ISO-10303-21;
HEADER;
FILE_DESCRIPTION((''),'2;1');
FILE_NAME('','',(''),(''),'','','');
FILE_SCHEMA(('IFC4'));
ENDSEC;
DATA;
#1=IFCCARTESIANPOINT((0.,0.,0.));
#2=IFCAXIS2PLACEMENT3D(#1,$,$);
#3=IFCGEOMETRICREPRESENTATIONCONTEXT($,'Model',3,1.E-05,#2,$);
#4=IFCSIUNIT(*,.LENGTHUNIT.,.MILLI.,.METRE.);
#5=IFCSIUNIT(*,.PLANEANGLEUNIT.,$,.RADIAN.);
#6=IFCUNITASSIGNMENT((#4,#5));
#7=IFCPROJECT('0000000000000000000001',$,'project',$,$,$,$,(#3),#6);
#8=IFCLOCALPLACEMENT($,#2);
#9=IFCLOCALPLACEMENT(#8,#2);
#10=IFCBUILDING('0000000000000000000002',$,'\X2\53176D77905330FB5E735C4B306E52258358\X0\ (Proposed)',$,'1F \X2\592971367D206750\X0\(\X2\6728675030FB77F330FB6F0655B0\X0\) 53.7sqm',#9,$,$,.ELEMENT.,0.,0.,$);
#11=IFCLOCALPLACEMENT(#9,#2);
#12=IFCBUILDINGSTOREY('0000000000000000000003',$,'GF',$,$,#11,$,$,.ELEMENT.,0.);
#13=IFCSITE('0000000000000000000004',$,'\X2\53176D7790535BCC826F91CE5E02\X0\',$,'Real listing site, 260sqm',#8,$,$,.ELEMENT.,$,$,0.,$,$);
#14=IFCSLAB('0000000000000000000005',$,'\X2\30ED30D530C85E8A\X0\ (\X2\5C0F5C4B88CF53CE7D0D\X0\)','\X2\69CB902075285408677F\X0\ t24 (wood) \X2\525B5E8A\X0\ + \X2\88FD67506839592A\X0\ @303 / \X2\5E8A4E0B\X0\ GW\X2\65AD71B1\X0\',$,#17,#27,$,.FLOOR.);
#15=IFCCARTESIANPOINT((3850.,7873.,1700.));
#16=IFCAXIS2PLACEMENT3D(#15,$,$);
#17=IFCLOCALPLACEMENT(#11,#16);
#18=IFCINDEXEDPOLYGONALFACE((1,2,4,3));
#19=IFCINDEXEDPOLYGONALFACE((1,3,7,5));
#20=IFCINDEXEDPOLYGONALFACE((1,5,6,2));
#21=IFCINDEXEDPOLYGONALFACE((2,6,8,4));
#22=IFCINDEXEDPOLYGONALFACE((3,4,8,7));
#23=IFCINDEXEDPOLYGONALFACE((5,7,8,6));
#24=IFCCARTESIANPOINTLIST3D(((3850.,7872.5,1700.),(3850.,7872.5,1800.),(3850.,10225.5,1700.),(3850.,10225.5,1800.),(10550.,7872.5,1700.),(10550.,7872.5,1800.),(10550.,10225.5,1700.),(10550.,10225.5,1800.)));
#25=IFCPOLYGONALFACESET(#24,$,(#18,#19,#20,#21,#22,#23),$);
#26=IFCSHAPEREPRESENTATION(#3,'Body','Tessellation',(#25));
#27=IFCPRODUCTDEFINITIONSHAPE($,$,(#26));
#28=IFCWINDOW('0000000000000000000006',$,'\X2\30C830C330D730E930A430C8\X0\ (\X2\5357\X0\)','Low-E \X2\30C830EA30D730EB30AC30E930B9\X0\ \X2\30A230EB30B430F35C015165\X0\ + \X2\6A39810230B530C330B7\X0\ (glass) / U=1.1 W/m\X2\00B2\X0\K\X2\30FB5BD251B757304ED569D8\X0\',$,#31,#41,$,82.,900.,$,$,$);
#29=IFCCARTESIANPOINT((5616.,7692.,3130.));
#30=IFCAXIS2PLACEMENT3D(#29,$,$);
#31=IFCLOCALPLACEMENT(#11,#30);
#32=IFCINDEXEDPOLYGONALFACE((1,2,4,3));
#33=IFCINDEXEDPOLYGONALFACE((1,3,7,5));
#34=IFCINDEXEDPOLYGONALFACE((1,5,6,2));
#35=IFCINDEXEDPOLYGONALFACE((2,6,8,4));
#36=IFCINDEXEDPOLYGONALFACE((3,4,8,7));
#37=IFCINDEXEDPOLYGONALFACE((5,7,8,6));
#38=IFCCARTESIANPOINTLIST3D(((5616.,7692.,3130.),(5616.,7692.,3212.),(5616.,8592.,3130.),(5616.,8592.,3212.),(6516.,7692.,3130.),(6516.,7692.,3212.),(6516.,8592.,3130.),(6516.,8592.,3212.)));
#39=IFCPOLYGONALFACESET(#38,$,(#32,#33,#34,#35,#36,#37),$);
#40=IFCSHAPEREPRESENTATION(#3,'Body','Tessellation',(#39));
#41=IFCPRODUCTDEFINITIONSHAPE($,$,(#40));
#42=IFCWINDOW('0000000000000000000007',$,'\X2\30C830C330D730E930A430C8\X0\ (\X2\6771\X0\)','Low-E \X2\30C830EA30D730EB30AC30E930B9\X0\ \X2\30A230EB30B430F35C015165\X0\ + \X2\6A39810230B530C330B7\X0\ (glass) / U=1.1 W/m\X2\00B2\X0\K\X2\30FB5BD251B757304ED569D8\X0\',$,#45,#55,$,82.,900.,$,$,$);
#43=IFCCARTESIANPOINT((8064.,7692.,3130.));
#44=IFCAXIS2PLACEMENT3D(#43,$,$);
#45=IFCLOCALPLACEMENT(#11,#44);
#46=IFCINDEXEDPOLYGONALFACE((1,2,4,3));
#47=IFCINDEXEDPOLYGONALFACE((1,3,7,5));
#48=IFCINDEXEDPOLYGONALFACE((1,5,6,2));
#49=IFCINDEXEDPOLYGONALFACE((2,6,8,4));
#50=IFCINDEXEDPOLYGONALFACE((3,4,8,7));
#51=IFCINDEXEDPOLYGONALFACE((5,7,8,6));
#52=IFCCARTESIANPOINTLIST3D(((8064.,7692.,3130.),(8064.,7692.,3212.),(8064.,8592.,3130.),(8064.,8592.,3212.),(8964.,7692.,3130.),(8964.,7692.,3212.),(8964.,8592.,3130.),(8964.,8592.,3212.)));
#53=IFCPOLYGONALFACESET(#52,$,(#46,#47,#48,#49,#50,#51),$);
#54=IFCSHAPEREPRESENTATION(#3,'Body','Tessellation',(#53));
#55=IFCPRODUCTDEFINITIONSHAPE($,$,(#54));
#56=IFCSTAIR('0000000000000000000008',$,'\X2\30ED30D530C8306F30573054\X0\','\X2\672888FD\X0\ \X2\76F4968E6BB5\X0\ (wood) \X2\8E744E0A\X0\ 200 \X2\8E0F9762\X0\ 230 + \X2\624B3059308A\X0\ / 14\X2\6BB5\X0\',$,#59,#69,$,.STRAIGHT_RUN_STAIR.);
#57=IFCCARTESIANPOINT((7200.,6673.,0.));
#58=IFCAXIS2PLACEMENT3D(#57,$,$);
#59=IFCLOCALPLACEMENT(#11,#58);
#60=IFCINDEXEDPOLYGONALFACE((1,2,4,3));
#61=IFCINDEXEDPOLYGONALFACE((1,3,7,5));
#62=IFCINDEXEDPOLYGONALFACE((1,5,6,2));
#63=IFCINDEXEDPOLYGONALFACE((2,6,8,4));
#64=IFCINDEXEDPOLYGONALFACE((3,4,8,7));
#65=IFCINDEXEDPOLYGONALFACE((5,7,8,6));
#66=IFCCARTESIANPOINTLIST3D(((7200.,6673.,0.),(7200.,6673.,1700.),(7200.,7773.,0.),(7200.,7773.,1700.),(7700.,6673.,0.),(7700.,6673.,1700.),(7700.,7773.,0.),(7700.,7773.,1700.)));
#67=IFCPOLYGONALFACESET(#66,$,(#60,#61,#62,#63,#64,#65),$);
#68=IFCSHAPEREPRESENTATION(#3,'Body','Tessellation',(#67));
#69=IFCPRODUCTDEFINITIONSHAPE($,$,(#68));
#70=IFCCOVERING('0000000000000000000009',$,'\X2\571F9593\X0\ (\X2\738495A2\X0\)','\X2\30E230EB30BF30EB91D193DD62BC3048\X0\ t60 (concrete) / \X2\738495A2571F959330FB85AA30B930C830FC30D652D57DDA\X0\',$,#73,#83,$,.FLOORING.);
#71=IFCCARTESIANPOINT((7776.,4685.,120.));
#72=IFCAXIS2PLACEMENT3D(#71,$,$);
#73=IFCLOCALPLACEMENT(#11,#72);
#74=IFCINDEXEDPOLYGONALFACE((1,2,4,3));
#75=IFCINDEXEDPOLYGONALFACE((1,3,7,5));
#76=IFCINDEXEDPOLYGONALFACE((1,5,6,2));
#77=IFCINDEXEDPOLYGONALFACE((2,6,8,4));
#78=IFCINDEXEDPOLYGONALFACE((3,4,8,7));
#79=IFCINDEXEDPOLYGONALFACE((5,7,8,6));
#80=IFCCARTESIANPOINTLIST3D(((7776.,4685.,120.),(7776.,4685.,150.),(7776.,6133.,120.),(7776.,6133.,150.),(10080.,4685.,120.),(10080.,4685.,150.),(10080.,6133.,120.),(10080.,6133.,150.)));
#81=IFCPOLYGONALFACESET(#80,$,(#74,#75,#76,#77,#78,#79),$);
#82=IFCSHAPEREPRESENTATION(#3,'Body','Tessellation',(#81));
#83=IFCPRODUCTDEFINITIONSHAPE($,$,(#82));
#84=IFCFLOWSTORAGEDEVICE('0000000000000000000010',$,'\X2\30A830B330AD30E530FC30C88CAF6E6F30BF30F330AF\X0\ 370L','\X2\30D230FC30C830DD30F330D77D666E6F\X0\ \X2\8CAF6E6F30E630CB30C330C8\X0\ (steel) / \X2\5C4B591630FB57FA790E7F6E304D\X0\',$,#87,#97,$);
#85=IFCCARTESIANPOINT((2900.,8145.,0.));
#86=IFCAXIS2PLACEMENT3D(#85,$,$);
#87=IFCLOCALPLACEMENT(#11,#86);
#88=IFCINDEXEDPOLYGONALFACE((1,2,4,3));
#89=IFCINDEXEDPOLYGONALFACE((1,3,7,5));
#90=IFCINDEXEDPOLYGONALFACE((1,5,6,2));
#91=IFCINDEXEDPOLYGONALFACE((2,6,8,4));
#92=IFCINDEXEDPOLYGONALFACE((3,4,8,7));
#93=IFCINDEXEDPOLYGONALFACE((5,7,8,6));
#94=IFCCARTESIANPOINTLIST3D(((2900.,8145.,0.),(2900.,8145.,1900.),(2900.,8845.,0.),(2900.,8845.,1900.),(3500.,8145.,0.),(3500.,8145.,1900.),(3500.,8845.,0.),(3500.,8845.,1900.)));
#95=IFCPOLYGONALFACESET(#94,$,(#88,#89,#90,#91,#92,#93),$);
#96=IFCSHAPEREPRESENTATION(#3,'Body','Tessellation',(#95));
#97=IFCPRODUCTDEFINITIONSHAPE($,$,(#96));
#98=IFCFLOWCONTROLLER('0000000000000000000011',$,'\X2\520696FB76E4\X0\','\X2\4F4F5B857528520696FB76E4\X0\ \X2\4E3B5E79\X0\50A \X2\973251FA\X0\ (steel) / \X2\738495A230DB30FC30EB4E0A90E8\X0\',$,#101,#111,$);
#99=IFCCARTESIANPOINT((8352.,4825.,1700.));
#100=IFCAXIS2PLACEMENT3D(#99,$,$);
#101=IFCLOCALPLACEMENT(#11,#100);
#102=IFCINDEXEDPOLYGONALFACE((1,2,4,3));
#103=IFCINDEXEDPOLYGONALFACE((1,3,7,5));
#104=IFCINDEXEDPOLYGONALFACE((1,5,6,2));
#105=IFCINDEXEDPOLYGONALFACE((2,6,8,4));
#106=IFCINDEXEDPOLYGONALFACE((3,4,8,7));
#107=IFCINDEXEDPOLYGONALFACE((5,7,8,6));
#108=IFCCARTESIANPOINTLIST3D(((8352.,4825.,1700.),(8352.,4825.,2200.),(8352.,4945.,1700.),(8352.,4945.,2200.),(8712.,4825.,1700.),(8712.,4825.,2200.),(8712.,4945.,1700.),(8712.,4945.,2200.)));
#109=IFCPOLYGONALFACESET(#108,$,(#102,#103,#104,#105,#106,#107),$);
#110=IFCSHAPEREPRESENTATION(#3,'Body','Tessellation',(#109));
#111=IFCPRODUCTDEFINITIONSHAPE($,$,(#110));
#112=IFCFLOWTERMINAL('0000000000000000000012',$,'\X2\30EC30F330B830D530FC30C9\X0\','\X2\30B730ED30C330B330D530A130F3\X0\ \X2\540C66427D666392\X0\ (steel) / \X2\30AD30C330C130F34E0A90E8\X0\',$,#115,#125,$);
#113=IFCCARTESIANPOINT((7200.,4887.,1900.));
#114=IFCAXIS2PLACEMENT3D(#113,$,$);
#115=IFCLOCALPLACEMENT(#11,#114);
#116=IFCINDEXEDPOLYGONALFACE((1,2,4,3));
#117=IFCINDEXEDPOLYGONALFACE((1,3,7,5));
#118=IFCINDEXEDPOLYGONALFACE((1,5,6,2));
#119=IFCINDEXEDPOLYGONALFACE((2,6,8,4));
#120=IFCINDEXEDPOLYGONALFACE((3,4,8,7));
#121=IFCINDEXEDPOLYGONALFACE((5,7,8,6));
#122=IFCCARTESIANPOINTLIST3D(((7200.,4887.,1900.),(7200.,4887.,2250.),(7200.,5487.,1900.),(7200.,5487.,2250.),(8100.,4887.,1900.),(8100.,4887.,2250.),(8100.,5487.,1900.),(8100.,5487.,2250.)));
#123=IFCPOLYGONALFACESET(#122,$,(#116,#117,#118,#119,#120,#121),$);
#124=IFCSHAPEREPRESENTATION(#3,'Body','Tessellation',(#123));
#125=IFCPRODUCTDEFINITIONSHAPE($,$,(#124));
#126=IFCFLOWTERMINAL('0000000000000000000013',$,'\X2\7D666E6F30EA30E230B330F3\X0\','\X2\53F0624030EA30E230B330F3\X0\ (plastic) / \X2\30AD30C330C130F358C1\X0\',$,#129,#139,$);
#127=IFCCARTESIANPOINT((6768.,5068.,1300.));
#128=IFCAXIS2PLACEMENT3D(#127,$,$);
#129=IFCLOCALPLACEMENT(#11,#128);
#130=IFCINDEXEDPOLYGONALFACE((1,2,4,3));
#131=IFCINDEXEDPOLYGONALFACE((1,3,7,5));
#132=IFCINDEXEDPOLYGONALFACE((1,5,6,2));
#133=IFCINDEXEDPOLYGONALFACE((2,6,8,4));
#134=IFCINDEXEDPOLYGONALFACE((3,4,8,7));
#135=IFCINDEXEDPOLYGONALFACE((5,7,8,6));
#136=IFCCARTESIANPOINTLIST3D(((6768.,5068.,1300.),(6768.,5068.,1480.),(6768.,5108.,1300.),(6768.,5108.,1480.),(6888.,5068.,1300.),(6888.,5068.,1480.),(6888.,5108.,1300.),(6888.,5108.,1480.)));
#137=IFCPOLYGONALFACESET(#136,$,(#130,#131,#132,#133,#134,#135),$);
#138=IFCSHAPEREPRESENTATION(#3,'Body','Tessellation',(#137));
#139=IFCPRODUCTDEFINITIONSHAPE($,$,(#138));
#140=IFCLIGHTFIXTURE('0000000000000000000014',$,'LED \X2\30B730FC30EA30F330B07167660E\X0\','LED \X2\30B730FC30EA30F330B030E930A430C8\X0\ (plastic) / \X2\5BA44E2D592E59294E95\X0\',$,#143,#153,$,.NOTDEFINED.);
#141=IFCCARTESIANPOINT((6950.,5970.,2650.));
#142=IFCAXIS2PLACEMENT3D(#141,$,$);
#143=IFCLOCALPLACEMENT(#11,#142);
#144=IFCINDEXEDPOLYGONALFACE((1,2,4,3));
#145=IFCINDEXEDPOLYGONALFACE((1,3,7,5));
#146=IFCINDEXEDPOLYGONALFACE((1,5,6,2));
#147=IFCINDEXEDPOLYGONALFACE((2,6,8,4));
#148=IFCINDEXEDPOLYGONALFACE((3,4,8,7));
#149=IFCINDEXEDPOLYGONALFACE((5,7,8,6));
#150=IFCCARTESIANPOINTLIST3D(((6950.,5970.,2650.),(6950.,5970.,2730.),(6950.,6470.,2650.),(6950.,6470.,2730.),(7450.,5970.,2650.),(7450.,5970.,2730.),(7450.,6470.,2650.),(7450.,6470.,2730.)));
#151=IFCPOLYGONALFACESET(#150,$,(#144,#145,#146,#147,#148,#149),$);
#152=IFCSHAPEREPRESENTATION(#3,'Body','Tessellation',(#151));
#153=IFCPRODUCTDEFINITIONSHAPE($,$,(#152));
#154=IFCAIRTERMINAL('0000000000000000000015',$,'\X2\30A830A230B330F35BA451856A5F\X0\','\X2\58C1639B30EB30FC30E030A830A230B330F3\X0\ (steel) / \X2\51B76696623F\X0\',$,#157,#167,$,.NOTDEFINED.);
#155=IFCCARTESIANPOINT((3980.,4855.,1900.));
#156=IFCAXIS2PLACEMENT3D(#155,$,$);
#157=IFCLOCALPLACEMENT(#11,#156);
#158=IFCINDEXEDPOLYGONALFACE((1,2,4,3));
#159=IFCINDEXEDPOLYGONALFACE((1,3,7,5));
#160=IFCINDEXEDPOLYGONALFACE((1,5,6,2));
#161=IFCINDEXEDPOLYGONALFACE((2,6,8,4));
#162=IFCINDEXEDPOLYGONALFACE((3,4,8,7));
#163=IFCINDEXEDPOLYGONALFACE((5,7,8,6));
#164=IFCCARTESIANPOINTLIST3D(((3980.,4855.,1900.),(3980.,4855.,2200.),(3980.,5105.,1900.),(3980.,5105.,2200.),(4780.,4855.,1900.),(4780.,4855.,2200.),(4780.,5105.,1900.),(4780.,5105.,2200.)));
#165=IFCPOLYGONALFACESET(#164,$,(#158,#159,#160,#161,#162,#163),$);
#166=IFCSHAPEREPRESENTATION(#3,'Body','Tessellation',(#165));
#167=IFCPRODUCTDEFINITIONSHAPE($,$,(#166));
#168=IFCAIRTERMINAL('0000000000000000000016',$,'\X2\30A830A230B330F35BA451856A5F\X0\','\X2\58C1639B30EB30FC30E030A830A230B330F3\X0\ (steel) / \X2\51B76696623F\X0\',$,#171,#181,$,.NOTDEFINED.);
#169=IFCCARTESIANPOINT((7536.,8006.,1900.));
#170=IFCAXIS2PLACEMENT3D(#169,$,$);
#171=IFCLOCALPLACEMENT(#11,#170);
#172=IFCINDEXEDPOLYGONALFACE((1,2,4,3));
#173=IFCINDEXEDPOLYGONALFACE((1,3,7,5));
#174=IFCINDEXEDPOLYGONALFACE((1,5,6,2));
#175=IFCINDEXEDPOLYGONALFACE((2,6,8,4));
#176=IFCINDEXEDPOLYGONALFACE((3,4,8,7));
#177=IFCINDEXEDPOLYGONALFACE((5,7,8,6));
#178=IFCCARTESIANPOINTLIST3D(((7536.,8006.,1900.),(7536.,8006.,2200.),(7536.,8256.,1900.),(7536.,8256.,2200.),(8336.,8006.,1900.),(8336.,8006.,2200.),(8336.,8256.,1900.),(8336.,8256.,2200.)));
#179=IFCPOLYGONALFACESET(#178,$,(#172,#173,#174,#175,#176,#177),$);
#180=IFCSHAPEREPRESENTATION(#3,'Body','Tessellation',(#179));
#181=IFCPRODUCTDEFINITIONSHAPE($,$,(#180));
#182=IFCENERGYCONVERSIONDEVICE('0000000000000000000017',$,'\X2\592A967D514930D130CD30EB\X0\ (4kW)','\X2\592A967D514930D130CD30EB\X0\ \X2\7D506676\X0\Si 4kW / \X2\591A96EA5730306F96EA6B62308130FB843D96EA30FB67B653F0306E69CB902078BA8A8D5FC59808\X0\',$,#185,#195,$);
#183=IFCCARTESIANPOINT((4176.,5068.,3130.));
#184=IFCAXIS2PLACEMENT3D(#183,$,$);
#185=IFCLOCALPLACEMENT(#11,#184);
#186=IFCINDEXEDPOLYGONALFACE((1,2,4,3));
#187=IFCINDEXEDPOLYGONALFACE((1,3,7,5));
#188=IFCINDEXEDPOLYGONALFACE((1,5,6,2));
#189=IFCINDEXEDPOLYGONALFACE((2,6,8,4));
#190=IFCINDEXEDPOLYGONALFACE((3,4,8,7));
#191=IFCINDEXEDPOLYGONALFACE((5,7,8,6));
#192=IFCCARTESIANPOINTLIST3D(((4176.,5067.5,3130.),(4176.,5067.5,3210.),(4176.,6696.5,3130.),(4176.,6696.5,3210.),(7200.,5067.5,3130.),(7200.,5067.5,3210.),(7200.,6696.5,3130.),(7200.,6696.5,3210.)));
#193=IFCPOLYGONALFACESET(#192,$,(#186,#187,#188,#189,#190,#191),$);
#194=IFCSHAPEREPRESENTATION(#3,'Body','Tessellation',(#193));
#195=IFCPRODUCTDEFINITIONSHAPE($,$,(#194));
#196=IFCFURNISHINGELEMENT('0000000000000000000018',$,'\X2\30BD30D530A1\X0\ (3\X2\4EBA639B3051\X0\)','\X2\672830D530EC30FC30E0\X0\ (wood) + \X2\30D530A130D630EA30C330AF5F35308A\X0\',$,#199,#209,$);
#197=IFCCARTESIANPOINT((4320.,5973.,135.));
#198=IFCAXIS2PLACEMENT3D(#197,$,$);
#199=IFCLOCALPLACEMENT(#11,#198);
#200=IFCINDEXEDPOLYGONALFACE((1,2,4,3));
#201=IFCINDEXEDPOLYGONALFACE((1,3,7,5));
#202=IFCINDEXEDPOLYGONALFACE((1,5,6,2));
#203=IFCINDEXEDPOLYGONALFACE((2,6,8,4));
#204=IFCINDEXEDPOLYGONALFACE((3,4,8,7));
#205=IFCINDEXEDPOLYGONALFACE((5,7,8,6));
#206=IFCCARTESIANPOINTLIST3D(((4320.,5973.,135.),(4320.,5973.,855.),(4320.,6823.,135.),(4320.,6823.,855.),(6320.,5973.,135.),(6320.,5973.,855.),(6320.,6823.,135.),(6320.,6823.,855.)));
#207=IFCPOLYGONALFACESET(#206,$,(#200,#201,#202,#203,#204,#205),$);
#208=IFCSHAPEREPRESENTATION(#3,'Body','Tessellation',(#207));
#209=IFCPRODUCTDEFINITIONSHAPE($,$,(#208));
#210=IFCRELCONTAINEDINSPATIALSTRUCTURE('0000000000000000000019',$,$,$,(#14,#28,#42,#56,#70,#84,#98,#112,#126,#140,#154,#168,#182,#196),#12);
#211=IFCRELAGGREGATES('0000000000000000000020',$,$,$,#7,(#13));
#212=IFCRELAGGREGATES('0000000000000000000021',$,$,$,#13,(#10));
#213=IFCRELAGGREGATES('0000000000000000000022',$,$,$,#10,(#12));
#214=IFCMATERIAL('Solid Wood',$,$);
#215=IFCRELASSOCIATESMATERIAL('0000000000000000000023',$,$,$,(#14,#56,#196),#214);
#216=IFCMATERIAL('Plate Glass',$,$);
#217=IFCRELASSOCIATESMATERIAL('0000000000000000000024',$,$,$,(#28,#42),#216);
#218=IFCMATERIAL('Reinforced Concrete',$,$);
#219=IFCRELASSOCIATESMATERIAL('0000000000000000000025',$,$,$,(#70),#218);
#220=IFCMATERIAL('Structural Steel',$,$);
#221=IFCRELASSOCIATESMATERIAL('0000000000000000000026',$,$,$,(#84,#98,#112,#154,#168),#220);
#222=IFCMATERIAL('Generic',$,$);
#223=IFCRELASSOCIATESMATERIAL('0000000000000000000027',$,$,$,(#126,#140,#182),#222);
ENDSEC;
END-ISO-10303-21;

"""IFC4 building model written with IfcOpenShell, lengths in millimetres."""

from ifc_helpers import new_model, si_unit, frame, frame_2d, origin, place, context, project, spatial, rectangle, extrude, material, element, save


model = new_model("IFC4")

# Units and contexts
model_context = context("Model", 3, precision=1e-05, world=origin())
ifc_project = project(units=[si_unit("LENGTHUNIT", "METRE", prefix="MILLI"), si_unit("PLANEANGLEUNIT", "RADIAN")], contexts=[model_context])

# Site, building, storey
site_placement = place(None, origin())
site = spatial("IfcSite", under=ifc_project, at=site_placement, Name="北海道富良野市", ObjectType="Real listing site, 260sqm", CompositionType="ELEMENT", RefElevation=0.0)
building_placement = place(site_placement, origin())
building = spatial("IfcBuilding", under=site, at=building_placement, Name="北海道・平屋の別荘 (Proposed)", ObjectType="1F 天然素材(木材・石・漆喰) 53.7sqm", CompositionType="ELEMENT", ElevationOfRefHeight=0.0, ElevationOfTerrain=0.0)
storey_placement = place(building_placement, origin())
storey = spatial("IfcBuildingStorey", under=building, at=storey_placement, Name="GF", CompositionType="ELEMENT", Elevation=0.0)

# Shared definitions
ifc_material_1 = material(Name="Solid Wood")

# Slab
slab_placement = place(storey_placement, frame((3850.0, 7873.0, 1700.0)))
element("IfcSlab", 1, at=slab_placement, inside=storey, material=ifc_material_1, Name="ロフト床 (小屋裏収納)", Description="構造用合板 t24 (wood) 剛床 + 製材根太 @303 / 床下 GW断熱", PredefinedType="FLOOR", context=model_context, shape_type="SweptSolid", body=[
    extrude(rectangle(XDim=6700.0, YDim=2353.0, at=frame_2d((3350.0, 1176.0))), frame((3850.0, 7873.0, 1700.0)), (0.0, 0.0, 1.0), 100.0),
])

# Windows
ifc_material_2 = material(Name="Plate Glass")
window_1_placement = place(storey_placement, frame((5616.0, 7692.0, 3130.0)))
element("IfcWindow", 2, at=window_1_placement, inside=storey, material=ifc_material_2, Name="トップライト (南)", Description="Low-E トリプルガラス アルゴン封入 + 樹脂サッシ (glass) / U=1.1 W/m²K・寒冷地仕様", OverallHeight=82.0, OverallWidth=900.0, context=model_context, shape_type="SweptSolid", body=[
    extrude(rectangle(XDim=900.0, YDim=900.0, at=frame_2d((450.0, 450.0))), frame((5616.0, 7692.0, 3130.0)), (0.0, 0.0, 1.0), 82.0),
])
window_2_placement = place(storey_placement, frame((8064.0, 7692.0, 3130.0)))
element("IfcWindow", 3, at=window_2_placement, inside=storey, material=ifc_material_2, Name="トップライト (東)", Description="Low-E トリプルガラス アルゴン封入 + 樹脂サッシ (glass) / U=1.1 W/m²K・寒冷地仕様", OverallHeight=82.0, OverallWidth=900.0, context=model_context, shape_type="SweptSolid", body=[
    extrude(rectangle(XDim=900.0, YDim=900.0, at=frame_2d((450.0, 450.0))), frame((8064.0, 7692.0, 3130.0)), (0.0, 0.0, 1.0), 82.0),
])

# Stair
stair_placement = place(storey_placement, frame((7200.0, 6673.0, 0.0)))
element("IfcStair", 4, at=stair_placement, inside=storey, material=ifc_material_1, Name="ロフトはしご", Description="木製 直階段 (wood) 蹴上 200 踏面 230 + 手すり / 14段", PredefinedType="STRAIGHT_RUN_STAIR", context=model_context, shape_type="SweptSolid", body=[
    extrude(rectangle(XDim=500.0, YDim=1100.0, at=frame_2d((250.0, 550.0))), frame((7200.0, 6673.0, 0.0)), (0.0, 0.0, 1.0), 1700.0),
])

# Covering
ifc_material_3 = material(Name="Reinforced Concrete")
covering_placement = place(storey_placement, frame((7776.0, 4685.0, 120.0)))
element("IfcCovering", 5, at=covering_placement, inside=storey, material=ifc_material_3, Name="土間 (玄関)", Description="モルタル金鏝押え t60 (concrete) / 玄関土間・薪ストーブ動線", PredefinedType="FLOORING", context=model_context, shape_type="SweptSolid", body=[
    extrude(rectangle(XDim=2304.0, YDim=1448.0, at=frame_2d((1152.0, 724.0))), frame((7776.0, 4685.0, 120.0)), (0.0, 0.0, 1.0), 30.0),
])

# Flow storage device
ifc_material_4 = material(Name="Structural Steel")
flow_storage_device_placement = place(storey_placement, frame((2900.0, 8145.0, 0.0)))
element("IfcFlowStorageDevice", 6, at=flow_storage_device_placement, inside=storey, material=ifc_material_4, Name="エコキュート貯湯タンク 370L", Description="ヒートポンプ給湯 貯湯ユニット (steel) / 屋外・基礎置き", context=model_context, shape_type="SweptSolid", body=[
    extrude(rectangle(XDim=600.0, YDim=700.0, at=frame_2d((300.0, 350.0))), frame((2900.0, 8145.0, 0.0)), (0.0, 0.0, 1.0), 1900.0),
])

# Flow controller
flow_controller_placement = place(storey_placement, frame((8352.0, 4825.0, 1700.0)))
element("IfcFlowController", 7, at=flow_controller_placement, inside=storey, material=ifc_material_4, Name="分電盤", Description="住宅用分電盤 主幹50A 露出 (steel) / 玄関ホール上部", context=model_context, shape_type="SweptSolid", body=[
    extrude(rectangle(XDim=360.0, YDim=120.0, at=frame_2d((180.0, 60.0))), frame((8352.0, 4825.0, 1700.0)), (0.0, 0.0, 1.0), 500.0),
])

# Flow terminals
flow_terminal_1_placement = place(storey_placement, frame((7200.0, 4887.0, 1900.0)))
element("IfcFlowTerminal", 8, at=flow_terminal_1_placement, inside=storey, material=ifc_material_4, Name="レンジフード", Description="シロッコファン 同時給排 (steel) / キッチン上部", context=model_context, shape_type="SweptSolid", body=[
    extrude(rectangle(XDim=900.0, YDim=600.0, at=frame_2d((450.0, 300.0))), frame((7200.0, 4887.0, 1900.0)), (0.0, 0.0, 1.0), 350.0),
])
ifc_material_5 = material(Name="Generic")
flow_terminal_2_placement = place(storey_placement, frame((6768.0, 5068.0, 1300.0)))
element("IfcFlowTerminal", 9, at=flow_terminal_2_placement, inside=storey, material=ifc_material_5, Name="給湯リモコン", Description="台所リモコン (plastic) / キッチン壁", context=model_context, shape_type="SweptSolid", body=[
    extrude(rectangle(XDim=120.0, YDim=40.0, at=frame_2d((60.0, 20.0))), frame((6768.0, 5068.0, 1300.0)), (0.0, 0.0, 1.0), 180.0),
])

# Light fixture
light_fixture_placement = place(storey_placement, frame((6950.0, 5970.0, 2650.0)))
element("IfcLightFixture", 10, at=light_fixture_placement, inside=storey, material=ifc_material_5, Name="LED シーリング照明", Description="LED シーリングライト (plastic) / 室中央天井", PredefinedType="NOTDEFINED", context=model_context, shape_type="SweptSolid", body=[
    extrude(rectangle(XDim=500.0, YDim=500.0, at=frame_2d((250.0, 250.0))), frame((6950.0, 5970.0, 2650.0)), (0.0, 0.0, 1.0), 80.0),
])

# Air terminals
air_terminal_1_placement = place(storey_placement, frame((3980.0, 4855.0, 1900.0)))
element("IfcAirTerminal", 11, at=air_terminal_1_placement, inside=storey, material=ifc_material_4, Name="エアコン室内機", Description="壁掛ルームエアコン (steel) / 冷暖房", PredefinedType="NOTDEFINED", context=model_context, shape_type="SweptSolid", body=[
    extrude(rectangle(XDim=800.0, YDim=250.0, at=frame_2d((400.0, 125.0))), frame((3980.0, 4855.0, 1900.0)), (0.0, 0.0, 1.0), 300.0),
])
air_terminal_2_placement = place(storey_placement, frame((7536.0, 8006.0, 1900.0)))
element("IfcAirTerminal", 12, at=air_terminal_2_placement, inside=storey, material=ifc_material_4, Name="エアコン室内機", Description="壁掛ルームエアコン (steel) / 冷暖房", PredefinedType="NOTDEFINED", context=model_context, shape_type="SweptSolid", body=[
    extrude(rectangle(XDim=800.0, YDim=250.0, at=frame_2d((400.0, 125.0))), frame((7536.0, 8006.0, 1900.0)), (0.0, 0.0, 1.0), 300.0),
])

# Energy conversion device
energy_conversion_device_placement = place(storey_placement, frame((4176.0, 5068.0, 3130.0)))
element("IfcEnergyConversionDevice", 13, at=energy_conversion_device_placement, inside=storey, material=ifc_material_5, Name="太陽光パネル (4kW)", Description="太陽光パネル 結晶Si 4kW / 多雪地は雪止め・落雪・架台の構造確認必須", context=model_context, shape_type="SweptSolid", body=[
    extrude(rectangle(XDim=3024.0, YDim=1629.0, at=frame_2d((1512.0, 814.0))), frame((4176.0, 5068.0, 3130.0)), (0.0, 0.0, 1.0), 80.0),
])

# Furnishing element
furnishing_1_placement = place(storey_placement, frame((4320.0, 5973.0, 135.0)))
element("IfcFurnishingElement", 14, at=furnishing_1_placement, inside=storey, material=ifc_material_1, Name="ソファ (3人掛け)", Description="木フレーム (wood) + ファブリック張り", context=model_context, shape_type="SweptSolid", body=[
    extrude(rectangle(XDim=2000.0, YDim=850.0, at=frame_2d((1000.0, 425.0))), frame((4320.0, 5973.0, 135.0)), (0.0, 0.0, 1.0), 720.0),
])

save(model, "model.ifc")
